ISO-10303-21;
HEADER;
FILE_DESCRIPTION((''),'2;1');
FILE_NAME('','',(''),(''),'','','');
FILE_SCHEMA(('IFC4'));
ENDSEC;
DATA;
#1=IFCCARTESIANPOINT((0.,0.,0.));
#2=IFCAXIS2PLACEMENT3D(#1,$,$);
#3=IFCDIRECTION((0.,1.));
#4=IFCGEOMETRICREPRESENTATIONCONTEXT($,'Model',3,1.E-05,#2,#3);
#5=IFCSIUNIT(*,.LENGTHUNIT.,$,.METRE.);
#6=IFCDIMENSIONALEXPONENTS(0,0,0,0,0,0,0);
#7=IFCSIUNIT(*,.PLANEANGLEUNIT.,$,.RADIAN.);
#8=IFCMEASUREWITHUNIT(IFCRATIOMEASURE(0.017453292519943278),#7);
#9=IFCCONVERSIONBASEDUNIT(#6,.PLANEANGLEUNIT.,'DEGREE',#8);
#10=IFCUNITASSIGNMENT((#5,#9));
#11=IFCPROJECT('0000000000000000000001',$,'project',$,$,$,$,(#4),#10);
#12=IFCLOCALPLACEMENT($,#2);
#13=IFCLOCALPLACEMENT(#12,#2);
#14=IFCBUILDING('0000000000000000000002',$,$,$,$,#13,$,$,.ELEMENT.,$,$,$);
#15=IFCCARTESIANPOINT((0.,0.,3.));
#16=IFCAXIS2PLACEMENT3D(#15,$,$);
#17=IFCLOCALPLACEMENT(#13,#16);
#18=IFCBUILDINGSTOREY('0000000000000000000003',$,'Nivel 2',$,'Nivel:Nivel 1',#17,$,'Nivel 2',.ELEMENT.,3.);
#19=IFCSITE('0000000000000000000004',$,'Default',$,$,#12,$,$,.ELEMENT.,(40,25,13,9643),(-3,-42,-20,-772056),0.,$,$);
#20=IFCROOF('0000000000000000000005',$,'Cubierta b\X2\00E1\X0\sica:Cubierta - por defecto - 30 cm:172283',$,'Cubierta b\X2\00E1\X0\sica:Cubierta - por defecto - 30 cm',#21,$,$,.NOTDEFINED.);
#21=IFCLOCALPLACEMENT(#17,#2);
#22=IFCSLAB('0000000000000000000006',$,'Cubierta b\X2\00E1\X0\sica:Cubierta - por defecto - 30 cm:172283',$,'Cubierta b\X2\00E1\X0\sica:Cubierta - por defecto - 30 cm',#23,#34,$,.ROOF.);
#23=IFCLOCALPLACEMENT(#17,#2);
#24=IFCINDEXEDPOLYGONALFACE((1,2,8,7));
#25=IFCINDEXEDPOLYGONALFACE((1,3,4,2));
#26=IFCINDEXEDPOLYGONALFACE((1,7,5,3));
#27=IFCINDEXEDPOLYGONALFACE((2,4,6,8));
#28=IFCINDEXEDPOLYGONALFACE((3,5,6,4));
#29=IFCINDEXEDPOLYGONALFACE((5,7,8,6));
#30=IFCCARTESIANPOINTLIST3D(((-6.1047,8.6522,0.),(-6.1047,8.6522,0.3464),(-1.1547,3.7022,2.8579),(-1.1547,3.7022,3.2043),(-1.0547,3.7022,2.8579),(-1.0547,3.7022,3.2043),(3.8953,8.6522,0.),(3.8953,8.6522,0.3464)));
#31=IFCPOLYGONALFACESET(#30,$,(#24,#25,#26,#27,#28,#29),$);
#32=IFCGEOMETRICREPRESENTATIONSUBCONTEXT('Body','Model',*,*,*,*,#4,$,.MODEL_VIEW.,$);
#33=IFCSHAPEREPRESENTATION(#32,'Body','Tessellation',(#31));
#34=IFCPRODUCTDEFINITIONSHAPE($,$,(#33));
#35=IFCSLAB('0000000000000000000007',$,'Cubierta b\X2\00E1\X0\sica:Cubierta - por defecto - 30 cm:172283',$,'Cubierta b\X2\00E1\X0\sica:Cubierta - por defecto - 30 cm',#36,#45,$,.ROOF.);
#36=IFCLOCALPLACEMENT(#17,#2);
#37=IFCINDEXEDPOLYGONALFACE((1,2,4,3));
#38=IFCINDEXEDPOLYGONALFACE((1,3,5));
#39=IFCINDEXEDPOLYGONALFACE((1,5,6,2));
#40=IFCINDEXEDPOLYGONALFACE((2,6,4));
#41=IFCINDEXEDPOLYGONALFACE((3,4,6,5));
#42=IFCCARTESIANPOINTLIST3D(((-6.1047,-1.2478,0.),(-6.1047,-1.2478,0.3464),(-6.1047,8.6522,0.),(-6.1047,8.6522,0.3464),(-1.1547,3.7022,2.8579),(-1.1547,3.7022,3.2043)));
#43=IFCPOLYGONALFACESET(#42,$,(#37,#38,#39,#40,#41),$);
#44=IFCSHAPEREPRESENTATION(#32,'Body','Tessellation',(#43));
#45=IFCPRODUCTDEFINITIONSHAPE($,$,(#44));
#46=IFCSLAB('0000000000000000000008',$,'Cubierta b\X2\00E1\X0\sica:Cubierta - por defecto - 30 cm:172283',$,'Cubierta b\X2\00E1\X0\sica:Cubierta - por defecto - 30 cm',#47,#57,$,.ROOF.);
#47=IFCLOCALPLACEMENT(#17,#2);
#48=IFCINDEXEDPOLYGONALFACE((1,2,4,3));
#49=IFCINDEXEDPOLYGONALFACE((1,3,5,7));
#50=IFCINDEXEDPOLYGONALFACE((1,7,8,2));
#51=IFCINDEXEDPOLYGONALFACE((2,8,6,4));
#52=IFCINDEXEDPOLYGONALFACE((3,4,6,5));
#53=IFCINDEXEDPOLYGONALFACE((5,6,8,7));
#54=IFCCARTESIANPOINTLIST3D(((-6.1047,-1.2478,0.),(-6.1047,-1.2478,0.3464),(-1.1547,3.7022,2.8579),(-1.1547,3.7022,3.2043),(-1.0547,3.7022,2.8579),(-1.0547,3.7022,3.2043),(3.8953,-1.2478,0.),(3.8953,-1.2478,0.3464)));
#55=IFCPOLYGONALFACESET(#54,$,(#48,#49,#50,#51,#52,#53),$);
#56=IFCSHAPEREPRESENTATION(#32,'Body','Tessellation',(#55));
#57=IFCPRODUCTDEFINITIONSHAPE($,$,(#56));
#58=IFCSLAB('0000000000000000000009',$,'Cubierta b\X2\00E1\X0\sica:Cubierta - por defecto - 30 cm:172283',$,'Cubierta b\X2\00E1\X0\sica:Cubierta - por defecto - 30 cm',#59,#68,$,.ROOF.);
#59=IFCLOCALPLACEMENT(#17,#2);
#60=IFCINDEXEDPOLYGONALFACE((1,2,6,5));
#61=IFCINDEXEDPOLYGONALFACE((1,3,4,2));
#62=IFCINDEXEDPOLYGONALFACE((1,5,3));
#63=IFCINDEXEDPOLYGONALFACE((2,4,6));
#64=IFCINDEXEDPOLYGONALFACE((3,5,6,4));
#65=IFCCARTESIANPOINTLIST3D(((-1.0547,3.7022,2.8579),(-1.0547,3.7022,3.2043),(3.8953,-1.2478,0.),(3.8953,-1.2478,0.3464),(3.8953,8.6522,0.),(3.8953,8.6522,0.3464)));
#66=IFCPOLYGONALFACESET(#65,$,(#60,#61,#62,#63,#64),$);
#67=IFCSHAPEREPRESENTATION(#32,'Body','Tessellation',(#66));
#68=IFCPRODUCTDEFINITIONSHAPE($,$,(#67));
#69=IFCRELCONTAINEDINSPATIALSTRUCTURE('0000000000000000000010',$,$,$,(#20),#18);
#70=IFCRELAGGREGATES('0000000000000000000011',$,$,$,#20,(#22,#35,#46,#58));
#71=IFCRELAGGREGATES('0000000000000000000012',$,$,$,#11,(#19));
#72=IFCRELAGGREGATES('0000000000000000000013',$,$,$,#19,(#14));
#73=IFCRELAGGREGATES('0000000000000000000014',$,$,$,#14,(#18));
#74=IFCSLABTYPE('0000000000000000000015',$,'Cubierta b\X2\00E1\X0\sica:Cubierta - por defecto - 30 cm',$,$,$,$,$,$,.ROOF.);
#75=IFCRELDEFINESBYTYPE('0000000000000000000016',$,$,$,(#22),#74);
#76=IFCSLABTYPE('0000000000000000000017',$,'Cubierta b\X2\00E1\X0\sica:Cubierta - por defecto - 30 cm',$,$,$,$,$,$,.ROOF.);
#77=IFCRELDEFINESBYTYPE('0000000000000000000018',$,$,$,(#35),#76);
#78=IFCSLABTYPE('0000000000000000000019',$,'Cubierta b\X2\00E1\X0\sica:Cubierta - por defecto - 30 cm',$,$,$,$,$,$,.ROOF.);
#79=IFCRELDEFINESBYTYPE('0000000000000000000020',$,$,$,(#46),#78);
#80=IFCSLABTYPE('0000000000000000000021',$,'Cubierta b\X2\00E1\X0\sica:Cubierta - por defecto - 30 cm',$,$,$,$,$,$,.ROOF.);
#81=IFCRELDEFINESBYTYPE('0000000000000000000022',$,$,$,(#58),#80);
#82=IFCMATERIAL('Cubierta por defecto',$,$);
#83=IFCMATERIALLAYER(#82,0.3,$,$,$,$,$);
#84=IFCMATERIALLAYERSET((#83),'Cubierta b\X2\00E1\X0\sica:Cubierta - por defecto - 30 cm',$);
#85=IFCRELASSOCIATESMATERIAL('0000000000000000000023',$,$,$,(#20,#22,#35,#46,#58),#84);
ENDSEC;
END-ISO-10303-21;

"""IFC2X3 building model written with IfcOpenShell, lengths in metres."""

from ifc_helpers import new_model, entity, si_unit, converted_unit, direction, frame, origin, place, context, subcontext, project, spatial, polyline, outline, extrude, material, layer, layer_set, type_object, element, aggregate, save


model = new_model("IFC2X3")

# Units and contexts
model_context = context("Model", 3, precision=1e-05, world=origin(), true_north=direction((0.0, 1.0)))
body_context = subcontext(model_context, "Body", "Model", "MODEL_VIEW")
ifc_project = project(units=[si_unit("LENGTHUNIT", "METRE"), converted_unit("PLANEANGLEUNIT", "DEGREE", entity("IfcRatioMeasure", 0.017453292519943278), si_unit("PLANEANGLEUNIT", "RADIAN"), dimensions=[0, 0, 0, 0, 0, 0, 0])], contexts=[model_context])

# Site, building, storey
site_placement = place(None, origin())
site = spatial("IfcSite", under=ifc_project, at=site_placement, Name="Default", CompositionType="ELEMENT", RefLatitude=(40, 25, 13, 9643), RefLongitude=(-3, -42, -20, -772056), RefElevation=0.0)
building_placement = place(site_placement, origin())
building = spatial("IfcBuilding", under=site, at=building_placement, CompositionType="ELEMENT")
storey_placement = place(building_placement, frame((0.0, 0.0, 3.0)))
storey = spatial("IfcBuildingStorey", under=building, at=storey_placement, Name="Nivel 2", ObjectType="Nivel:Nivel 1", LongName="Nivel 2", CompositionType="ELEMENT", Elevation=3.0)

# Roof, slabs
ifc_material = material(Name="Cubierta por defecto")
ifc_layer = layer(ifc_material, 0.3)
ifc_layer_set = layer_set([ifc_layer], Name="Cubierta básica:Cubierta - por defecto - 30 cm")
roof_placement = place(storey_placement, frame((-6.1047, -1.2478, 0.0)))
roof = element("IfcRoof", 1, at=roof_placement, inside=storey, material=ifc_layer_set, Name="Cubierta básica:Cubierta - por defecto - 30 cm:172283", ObjectType="Cubierta básica:Cubierta - por defecto - 30 cm", ShapeType="NOTDEFINED")
slab_type_1 = type_object("IfcSlabType", Name="Cubierta básica:Cubierta - por defecto - 30 cm", PredefinedType="ROOF")
slab_1_placement = place(roof_placement, origin())
slab_1 = element("IfcSlab", 2, at=slab_1_placement, type_object=slab_type_1, material=ifc_layer_set, Name="Cubierta básica:Cubierta - por defecto - 30 cm:172283", ObjectType="Cubierta básica:Cubierta - por defecto - 30 cm", PredefinedType="ROOF", context=body_context, shape_type="SweptSolid", body=[
    extrude(outline(polyline([(5.0, 2.8579), (-5.0, 2.8579), (-0.05, -2.8579), (0.05, -2.8579), (5.0, 2.8579)])), frame((5.0, 7.425, 1.4289), z_axis=(0.0, 0.5, 0.866025), x_axis=(1.0, 0.0, 0.0)), (0.0, -0.5, 0.866025), 0.3464),
])
slab_type_2 = type_object("IfcSlabType", Name="Cubierta básica:Cubierta - por defecto - 30 cm", PredefinedType="ROOF")
slab_2_placement = place(roof_placement, origin())
slab_2 = element("IfcSlab", 3, at=slab_2_placement, type_object=slab_type_2, material=ifc_layer_set, Name="Cubierta básica:Cubierta - por defecto - 30 cm:172283", ObjectType="Cubierta básica:Cubierta - por defecto - 30 cm", PredefinedType="ROOF", context=body_context, shape_type="SweptSolid", body=[
    extrude(outline(polyline([(-2.8579, 4.95), (-2.8579, -4.95), (2.8579, 0.0), (-2.8579, 4.95)])), frame((2.475, 4.95, 1.4289), z_axis=(-0.5, 0.0, 0.866025), x_axis=(0.866025, 0.0, 0.5)), (0.5, 0.0, 0.866025), 0.3464),
])
slab_type_3 = type_object("IfcSlabType", Name="Cubierta básica:Cubierta - por defecto - 30 cm", PredefinedType="ROOF")
slab_3_placement = place(roof_placement, origin())
slab_3 = element("IfcSlab", 4, at=slab_3_placement, type_object=slab_type_3, material=ifc_layer_set, Name="Cubierta básica:Cubierta - por defecto - 30 cm:172283", ObjectType="Cubierta básica:Cubierta - por defecto - 30 cm", PredefinedType="ROOF", context=body_context, shape_type="SweptSolid", body=[
    extrude(outline(polyline([(-5.0, -2.8579), (5.0, -2.8579), (0.05, 2.8579), (-0.05, 2.8579), (-5.0, -2.8579)])), frame((5.0, 2.475, 1.4289), z_axis=(0.0, -0.5, 0.866025), x_axis=(1.0, 0.0, 0.0)), (0.0, 0.5, 0.866025), 0.3464),
])
slab_type_4 = type_object("IfcSlabType", Name="Cubierta básica:Cubierta - por defecto - 30 cm", PredefinedType="ROOF")
slab_4_placement = place(roof_placement, origin())
slab_4 = element("IfcSlab", 5, at=slab_4_placement, type_object=slab_type_4, material=ifc_layer_set, Name="Cubierta básica:Cubierta - por defecto - 30 cm:172283", ObjectType="Cubierta básica:Cubierta - por defecto - 30 cm", PredefinedType="ROOF", context=body_context, shape_type="SweptSolid", body=[
    extrude(outline(polyline([(-2.8579, 0.0), (2.8579, -4.95), (2.8579, 4.95), (-2.8579, 0.0)])), frame((7.525, 4.95, 1.4289), z_axis=(0.5, 0.0, 0.866025), x_axis=(0.866025, 0.0, -0.5)), (-0.5, 0.0, 0.866025), 0.3464),
])
aggregate(roof, [slab_1, slab_2, slab_3, slab_4])

save(model, "model.ifc")
